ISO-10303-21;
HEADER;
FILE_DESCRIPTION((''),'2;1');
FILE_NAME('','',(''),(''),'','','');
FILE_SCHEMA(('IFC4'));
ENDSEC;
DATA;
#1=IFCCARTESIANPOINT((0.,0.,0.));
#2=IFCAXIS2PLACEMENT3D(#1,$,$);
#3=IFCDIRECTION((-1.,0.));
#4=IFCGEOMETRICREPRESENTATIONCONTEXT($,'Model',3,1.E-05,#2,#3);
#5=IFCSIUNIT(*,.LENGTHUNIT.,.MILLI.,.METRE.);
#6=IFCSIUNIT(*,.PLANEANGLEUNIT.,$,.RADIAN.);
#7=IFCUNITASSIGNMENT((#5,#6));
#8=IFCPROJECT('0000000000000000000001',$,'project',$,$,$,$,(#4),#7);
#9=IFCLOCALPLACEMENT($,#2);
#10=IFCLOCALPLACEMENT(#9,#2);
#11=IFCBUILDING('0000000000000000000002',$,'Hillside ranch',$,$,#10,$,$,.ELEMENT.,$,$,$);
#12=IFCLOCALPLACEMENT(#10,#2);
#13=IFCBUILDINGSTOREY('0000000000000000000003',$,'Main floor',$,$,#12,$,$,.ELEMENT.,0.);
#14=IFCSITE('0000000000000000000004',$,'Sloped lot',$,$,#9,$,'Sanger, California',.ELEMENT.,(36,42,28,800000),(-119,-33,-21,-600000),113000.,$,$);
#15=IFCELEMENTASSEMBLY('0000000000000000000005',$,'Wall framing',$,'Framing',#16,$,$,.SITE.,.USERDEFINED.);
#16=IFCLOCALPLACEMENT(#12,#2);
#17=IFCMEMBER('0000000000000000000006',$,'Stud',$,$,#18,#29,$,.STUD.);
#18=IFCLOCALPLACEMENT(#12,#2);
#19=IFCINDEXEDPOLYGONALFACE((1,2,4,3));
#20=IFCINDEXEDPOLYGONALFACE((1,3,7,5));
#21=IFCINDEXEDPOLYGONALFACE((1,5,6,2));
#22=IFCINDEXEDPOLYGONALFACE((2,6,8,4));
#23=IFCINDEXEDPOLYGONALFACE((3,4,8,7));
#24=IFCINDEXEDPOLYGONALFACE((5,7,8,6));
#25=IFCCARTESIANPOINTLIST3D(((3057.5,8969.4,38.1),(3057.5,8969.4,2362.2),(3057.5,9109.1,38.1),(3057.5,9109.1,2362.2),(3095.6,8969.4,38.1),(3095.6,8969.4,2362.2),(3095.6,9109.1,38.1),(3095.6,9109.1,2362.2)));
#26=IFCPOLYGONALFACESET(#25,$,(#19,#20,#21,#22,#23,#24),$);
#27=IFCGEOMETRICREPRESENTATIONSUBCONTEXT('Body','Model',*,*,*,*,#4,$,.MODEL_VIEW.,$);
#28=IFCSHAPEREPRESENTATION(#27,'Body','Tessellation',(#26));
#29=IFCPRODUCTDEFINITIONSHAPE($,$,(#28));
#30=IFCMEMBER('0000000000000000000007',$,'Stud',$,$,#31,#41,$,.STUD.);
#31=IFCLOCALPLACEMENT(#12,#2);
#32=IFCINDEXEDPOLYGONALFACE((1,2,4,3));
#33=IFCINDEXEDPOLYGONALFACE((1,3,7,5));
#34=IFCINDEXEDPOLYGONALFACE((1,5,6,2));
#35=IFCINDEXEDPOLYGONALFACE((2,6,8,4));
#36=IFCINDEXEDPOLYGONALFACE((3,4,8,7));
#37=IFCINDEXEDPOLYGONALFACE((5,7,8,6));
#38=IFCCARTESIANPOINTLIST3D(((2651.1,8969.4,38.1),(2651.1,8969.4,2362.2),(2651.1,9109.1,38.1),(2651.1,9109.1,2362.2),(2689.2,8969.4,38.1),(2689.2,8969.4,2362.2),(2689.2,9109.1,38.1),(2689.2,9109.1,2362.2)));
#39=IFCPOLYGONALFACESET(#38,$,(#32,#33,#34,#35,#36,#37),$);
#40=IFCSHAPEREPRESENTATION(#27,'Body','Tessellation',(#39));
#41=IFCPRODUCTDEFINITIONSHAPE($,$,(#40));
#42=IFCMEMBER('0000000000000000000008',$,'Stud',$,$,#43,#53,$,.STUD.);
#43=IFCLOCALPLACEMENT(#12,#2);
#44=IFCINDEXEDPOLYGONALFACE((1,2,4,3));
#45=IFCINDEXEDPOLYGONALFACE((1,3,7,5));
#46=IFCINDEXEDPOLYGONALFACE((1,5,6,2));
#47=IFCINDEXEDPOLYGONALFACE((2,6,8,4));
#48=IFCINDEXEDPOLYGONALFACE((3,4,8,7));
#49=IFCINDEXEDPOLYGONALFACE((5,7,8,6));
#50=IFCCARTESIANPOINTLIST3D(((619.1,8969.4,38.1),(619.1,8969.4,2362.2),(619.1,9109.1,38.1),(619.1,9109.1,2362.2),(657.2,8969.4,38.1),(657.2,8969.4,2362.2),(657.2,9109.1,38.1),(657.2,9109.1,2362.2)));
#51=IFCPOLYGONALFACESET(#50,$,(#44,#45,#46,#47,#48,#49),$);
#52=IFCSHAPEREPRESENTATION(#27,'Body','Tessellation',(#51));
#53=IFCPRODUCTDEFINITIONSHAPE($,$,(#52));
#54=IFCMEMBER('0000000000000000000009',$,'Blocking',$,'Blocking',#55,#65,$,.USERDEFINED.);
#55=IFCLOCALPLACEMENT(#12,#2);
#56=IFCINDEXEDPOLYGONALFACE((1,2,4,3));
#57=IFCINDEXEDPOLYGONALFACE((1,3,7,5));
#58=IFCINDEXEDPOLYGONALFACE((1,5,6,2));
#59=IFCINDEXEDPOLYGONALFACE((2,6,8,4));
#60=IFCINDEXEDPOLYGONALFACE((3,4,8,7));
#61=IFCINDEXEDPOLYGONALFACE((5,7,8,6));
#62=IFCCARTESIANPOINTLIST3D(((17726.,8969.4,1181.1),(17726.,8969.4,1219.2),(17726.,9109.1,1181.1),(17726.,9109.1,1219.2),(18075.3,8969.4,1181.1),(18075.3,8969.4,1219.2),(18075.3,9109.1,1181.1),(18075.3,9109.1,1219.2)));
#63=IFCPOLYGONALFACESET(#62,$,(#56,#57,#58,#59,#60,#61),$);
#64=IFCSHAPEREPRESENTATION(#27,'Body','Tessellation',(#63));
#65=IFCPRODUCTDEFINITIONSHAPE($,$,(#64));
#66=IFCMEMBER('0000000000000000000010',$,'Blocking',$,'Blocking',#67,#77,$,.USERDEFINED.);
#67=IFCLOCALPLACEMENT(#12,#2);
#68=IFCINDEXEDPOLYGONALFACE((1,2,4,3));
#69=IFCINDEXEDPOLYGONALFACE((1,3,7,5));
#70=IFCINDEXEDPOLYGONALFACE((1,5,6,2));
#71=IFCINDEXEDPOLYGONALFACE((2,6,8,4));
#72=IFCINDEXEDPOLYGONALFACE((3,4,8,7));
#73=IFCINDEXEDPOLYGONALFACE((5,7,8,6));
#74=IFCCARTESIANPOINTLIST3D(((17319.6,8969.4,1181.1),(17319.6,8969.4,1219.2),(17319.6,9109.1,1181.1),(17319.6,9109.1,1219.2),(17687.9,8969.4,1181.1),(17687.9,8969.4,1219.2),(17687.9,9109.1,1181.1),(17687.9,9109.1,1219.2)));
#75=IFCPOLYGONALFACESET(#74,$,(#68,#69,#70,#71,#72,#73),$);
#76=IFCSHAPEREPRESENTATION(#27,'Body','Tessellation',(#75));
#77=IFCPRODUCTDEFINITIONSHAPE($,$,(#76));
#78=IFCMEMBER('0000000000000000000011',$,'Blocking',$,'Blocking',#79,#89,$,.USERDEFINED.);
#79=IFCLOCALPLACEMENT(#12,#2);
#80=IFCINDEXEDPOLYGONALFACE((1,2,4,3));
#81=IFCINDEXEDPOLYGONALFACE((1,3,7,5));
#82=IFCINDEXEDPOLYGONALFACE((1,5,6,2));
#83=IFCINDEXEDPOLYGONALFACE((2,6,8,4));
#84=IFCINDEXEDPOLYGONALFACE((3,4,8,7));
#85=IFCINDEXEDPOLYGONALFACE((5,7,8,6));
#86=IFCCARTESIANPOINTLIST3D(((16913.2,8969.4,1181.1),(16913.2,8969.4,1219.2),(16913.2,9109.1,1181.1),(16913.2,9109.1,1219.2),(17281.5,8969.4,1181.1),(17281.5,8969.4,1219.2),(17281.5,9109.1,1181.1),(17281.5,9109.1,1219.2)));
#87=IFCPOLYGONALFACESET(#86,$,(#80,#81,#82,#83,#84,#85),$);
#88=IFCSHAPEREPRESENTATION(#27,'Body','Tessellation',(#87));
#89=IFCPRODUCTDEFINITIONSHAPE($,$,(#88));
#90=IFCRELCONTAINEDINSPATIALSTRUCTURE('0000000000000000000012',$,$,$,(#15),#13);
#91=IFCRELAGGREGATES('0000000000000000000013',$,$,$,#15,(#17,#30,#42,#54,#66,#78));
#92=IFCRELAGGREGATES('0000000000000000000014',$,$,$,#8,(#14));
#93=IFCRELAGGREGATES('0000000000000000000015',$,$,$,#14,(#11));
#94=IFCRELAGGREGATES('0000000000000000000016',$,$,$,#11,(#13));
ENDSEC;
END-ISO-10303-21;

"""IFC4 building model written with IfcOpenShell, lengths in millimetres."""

from ifc_helpers import new_model, si_unit, direction, frame, origin, origin_with_axes, place, context, subcontext, project, spatial, polyline, outline, extrude, element, aggregate, save


model = new_model("IFC4")

# Units and contexts
model_context = context("Model", 3, precision=1e-05, world=origin(), true_north=direction((-1.0, 0.0)))
body_context = subcontext(model_context, "Body", "Model", "MODEL_VIEW")
ifc_project = project(units=[si_unit("LENGTHUNIT", "METRE", prefix="MILLI"), si_unit("PLANEANGLEUNIT", "RADIAN")], contexts=[model_context])

# Site, building, storey
site_placement = place(None, origin())
site = spatial("IfcSite", under=ifc_project, at=site_placement, Name="Sloped lot", LongName="Sanger, California", CompositionType="ELEMENT", RefLatitude=(36, 42, 28, 800000), RefLongitude=(-119, -33, -21, -600000), RefElevation=113000.0)
building_placement = place(site_placement, origin())
building = spatial("IfcBuilding", under=site, at=building_placement, Name="Hillside ranch", CompositionType="ELEMENT")
storey_placement = place(building_placement, origin())
storey = spatial("IfcBuildingStorey", under=building, at=storey_placement, Name="Main floor", CompositionType="ELEMENT", Elevation=0.0)

# Element assembly, members
assembly_placement = place(storey_placement, origin_with_axes())
assembly = element("IfcElementAssembly", 1, at=assembly_placement, inside=storey, Name="Wall framing", ObjectType="Framing", AssemblyPlace="SITE", PredefinedType="USERDEFINED")
member_1_placement = place(storey_placement, origin_with_axes())
member_1 = element("IfcMember", 2, at=member_1_placement, Name="Stud", PredefinedType="STUD", context=body_context, shape_type="SweptSolid", body=[
    extrude(outline(polyline([(0.0, 0.0), (38.1, 0.0), (38.1, 139.7), (0.0, 139.7), (0.0, 0.0)])), frame((3095.6, 9109.1, 38.1), z_axis=(0.0, 0.0, 1.0), x_axis=(-1.0, 0.0, 0.0)), (0.0, 0.0, 1.0), 2324.1),
])
member_2_placement = place(storey_placement, origin_with_axes())
member_2 = element("IfcMember", 3, at=member_2_placement, Name="Stud", PredefinedType="STUD", context=body_context, shape_type="SweptSolid", body=[
    extrude(outline(polyline([(0.0, 0.0), (38.1, 0.0), (38.1, 139.7), (0.0, 139.7), (0.0, 0.0)])), frame((2689.2, 9109.1, 38.1), z_axis=(0.0, 0.0, 1.0), x_axis=(-1.0, 0.0, 0.0)), (0.0, 0.0, 1.0), 2324.1),
])
member_3_placement = place(storey_placement, origin_with_axes())
member_3 = element("IfcMember", 4, at=member_3_placement, Name="Stud", PredefinedType="STUD", context=body_context, shape_type="SweptSolid", body=[
    extrude(outline(polyline([(0.0, 0.0), (38.1, 0.0), (38.1, 139.7), (0.0, 139.7), (0.0, 0.0)])), frame((657.2, 9109.1, 38.1), z_axis=(0.0, 0.0, 1.0), x_axis=(-1.0, 0.0, 0.0)), (0.0, 0.0, 1.0), 2324.1),
])
member_4_placement = place(storey_placement, origin_with_axes())
member_4 = element("IfcMember", 5, at=member_4_placement, Name="Blocking", ObjectType="Blocking", PredefinedType="USERDEFINED", context=body_context, shape_type="SweptSolid", body=[
    extrude(outline(polyline([(0.0, 0.0), (349.2, 0.0), (349.2, 139.7), (0.0, 139.7), (0.0, 0.0)])), frame((18075.3, 9109.1, 1181.1), z_axis=(0.0, 0.0, 1.0), x_axis=(-1.0, 0.0, 0.0)), (0.0, 0.0, 1.0), 38.1),
])
member_5_placement = place(storey_placement, origin_with_axes())
member_5 = element("IfcMember", 6, at=member_5_placement, Name="Blocking", ObjectType="Blocking", PredefinedType="USERDEFINED", context=body_context, shape_type="SweptSolid", body=[
    extrude(outline(polyline([(0.0, 0.0), (368.3, 0.0), (368.3, 139.7), (0.0, 139.7), (0.0, 0.0)])), frame((17687.9, 9109.1, 1181.1), z_axis=(0.0, 0.0, 1.0), x_axis=(-1.0, 0.0, 0.0)), (0.0, 0.0, 1.0), 38.1),
])
member_6_placement = place(storey_placement, origin_with_axes())
member_6 = element("IfcMember", 7, at=member_6_placement, Name="Blocking", ObjectType="Blocking", PredefinedType="USERDEFINED", context=body_context, shape_type="SweptSolid", body=[
    extrude(outline(polyline([(0.0, 0.0), (368.3, 0.0), (368.3, 139.7), (0.0, 139.7), (0.0, 0.0)])), frame((17281.5, 9109.1, 1181.1), z_axis=(0.0, 0.0, 1.0), x_axis=(-1.0, 0.0, 0.0)), (0.0, 0.0, 1.0), 38.1),
])
aggregate(assembly, [member_1, member_2, member_3, member_4, member_5, member_6])

save(model, "model.ifc")
